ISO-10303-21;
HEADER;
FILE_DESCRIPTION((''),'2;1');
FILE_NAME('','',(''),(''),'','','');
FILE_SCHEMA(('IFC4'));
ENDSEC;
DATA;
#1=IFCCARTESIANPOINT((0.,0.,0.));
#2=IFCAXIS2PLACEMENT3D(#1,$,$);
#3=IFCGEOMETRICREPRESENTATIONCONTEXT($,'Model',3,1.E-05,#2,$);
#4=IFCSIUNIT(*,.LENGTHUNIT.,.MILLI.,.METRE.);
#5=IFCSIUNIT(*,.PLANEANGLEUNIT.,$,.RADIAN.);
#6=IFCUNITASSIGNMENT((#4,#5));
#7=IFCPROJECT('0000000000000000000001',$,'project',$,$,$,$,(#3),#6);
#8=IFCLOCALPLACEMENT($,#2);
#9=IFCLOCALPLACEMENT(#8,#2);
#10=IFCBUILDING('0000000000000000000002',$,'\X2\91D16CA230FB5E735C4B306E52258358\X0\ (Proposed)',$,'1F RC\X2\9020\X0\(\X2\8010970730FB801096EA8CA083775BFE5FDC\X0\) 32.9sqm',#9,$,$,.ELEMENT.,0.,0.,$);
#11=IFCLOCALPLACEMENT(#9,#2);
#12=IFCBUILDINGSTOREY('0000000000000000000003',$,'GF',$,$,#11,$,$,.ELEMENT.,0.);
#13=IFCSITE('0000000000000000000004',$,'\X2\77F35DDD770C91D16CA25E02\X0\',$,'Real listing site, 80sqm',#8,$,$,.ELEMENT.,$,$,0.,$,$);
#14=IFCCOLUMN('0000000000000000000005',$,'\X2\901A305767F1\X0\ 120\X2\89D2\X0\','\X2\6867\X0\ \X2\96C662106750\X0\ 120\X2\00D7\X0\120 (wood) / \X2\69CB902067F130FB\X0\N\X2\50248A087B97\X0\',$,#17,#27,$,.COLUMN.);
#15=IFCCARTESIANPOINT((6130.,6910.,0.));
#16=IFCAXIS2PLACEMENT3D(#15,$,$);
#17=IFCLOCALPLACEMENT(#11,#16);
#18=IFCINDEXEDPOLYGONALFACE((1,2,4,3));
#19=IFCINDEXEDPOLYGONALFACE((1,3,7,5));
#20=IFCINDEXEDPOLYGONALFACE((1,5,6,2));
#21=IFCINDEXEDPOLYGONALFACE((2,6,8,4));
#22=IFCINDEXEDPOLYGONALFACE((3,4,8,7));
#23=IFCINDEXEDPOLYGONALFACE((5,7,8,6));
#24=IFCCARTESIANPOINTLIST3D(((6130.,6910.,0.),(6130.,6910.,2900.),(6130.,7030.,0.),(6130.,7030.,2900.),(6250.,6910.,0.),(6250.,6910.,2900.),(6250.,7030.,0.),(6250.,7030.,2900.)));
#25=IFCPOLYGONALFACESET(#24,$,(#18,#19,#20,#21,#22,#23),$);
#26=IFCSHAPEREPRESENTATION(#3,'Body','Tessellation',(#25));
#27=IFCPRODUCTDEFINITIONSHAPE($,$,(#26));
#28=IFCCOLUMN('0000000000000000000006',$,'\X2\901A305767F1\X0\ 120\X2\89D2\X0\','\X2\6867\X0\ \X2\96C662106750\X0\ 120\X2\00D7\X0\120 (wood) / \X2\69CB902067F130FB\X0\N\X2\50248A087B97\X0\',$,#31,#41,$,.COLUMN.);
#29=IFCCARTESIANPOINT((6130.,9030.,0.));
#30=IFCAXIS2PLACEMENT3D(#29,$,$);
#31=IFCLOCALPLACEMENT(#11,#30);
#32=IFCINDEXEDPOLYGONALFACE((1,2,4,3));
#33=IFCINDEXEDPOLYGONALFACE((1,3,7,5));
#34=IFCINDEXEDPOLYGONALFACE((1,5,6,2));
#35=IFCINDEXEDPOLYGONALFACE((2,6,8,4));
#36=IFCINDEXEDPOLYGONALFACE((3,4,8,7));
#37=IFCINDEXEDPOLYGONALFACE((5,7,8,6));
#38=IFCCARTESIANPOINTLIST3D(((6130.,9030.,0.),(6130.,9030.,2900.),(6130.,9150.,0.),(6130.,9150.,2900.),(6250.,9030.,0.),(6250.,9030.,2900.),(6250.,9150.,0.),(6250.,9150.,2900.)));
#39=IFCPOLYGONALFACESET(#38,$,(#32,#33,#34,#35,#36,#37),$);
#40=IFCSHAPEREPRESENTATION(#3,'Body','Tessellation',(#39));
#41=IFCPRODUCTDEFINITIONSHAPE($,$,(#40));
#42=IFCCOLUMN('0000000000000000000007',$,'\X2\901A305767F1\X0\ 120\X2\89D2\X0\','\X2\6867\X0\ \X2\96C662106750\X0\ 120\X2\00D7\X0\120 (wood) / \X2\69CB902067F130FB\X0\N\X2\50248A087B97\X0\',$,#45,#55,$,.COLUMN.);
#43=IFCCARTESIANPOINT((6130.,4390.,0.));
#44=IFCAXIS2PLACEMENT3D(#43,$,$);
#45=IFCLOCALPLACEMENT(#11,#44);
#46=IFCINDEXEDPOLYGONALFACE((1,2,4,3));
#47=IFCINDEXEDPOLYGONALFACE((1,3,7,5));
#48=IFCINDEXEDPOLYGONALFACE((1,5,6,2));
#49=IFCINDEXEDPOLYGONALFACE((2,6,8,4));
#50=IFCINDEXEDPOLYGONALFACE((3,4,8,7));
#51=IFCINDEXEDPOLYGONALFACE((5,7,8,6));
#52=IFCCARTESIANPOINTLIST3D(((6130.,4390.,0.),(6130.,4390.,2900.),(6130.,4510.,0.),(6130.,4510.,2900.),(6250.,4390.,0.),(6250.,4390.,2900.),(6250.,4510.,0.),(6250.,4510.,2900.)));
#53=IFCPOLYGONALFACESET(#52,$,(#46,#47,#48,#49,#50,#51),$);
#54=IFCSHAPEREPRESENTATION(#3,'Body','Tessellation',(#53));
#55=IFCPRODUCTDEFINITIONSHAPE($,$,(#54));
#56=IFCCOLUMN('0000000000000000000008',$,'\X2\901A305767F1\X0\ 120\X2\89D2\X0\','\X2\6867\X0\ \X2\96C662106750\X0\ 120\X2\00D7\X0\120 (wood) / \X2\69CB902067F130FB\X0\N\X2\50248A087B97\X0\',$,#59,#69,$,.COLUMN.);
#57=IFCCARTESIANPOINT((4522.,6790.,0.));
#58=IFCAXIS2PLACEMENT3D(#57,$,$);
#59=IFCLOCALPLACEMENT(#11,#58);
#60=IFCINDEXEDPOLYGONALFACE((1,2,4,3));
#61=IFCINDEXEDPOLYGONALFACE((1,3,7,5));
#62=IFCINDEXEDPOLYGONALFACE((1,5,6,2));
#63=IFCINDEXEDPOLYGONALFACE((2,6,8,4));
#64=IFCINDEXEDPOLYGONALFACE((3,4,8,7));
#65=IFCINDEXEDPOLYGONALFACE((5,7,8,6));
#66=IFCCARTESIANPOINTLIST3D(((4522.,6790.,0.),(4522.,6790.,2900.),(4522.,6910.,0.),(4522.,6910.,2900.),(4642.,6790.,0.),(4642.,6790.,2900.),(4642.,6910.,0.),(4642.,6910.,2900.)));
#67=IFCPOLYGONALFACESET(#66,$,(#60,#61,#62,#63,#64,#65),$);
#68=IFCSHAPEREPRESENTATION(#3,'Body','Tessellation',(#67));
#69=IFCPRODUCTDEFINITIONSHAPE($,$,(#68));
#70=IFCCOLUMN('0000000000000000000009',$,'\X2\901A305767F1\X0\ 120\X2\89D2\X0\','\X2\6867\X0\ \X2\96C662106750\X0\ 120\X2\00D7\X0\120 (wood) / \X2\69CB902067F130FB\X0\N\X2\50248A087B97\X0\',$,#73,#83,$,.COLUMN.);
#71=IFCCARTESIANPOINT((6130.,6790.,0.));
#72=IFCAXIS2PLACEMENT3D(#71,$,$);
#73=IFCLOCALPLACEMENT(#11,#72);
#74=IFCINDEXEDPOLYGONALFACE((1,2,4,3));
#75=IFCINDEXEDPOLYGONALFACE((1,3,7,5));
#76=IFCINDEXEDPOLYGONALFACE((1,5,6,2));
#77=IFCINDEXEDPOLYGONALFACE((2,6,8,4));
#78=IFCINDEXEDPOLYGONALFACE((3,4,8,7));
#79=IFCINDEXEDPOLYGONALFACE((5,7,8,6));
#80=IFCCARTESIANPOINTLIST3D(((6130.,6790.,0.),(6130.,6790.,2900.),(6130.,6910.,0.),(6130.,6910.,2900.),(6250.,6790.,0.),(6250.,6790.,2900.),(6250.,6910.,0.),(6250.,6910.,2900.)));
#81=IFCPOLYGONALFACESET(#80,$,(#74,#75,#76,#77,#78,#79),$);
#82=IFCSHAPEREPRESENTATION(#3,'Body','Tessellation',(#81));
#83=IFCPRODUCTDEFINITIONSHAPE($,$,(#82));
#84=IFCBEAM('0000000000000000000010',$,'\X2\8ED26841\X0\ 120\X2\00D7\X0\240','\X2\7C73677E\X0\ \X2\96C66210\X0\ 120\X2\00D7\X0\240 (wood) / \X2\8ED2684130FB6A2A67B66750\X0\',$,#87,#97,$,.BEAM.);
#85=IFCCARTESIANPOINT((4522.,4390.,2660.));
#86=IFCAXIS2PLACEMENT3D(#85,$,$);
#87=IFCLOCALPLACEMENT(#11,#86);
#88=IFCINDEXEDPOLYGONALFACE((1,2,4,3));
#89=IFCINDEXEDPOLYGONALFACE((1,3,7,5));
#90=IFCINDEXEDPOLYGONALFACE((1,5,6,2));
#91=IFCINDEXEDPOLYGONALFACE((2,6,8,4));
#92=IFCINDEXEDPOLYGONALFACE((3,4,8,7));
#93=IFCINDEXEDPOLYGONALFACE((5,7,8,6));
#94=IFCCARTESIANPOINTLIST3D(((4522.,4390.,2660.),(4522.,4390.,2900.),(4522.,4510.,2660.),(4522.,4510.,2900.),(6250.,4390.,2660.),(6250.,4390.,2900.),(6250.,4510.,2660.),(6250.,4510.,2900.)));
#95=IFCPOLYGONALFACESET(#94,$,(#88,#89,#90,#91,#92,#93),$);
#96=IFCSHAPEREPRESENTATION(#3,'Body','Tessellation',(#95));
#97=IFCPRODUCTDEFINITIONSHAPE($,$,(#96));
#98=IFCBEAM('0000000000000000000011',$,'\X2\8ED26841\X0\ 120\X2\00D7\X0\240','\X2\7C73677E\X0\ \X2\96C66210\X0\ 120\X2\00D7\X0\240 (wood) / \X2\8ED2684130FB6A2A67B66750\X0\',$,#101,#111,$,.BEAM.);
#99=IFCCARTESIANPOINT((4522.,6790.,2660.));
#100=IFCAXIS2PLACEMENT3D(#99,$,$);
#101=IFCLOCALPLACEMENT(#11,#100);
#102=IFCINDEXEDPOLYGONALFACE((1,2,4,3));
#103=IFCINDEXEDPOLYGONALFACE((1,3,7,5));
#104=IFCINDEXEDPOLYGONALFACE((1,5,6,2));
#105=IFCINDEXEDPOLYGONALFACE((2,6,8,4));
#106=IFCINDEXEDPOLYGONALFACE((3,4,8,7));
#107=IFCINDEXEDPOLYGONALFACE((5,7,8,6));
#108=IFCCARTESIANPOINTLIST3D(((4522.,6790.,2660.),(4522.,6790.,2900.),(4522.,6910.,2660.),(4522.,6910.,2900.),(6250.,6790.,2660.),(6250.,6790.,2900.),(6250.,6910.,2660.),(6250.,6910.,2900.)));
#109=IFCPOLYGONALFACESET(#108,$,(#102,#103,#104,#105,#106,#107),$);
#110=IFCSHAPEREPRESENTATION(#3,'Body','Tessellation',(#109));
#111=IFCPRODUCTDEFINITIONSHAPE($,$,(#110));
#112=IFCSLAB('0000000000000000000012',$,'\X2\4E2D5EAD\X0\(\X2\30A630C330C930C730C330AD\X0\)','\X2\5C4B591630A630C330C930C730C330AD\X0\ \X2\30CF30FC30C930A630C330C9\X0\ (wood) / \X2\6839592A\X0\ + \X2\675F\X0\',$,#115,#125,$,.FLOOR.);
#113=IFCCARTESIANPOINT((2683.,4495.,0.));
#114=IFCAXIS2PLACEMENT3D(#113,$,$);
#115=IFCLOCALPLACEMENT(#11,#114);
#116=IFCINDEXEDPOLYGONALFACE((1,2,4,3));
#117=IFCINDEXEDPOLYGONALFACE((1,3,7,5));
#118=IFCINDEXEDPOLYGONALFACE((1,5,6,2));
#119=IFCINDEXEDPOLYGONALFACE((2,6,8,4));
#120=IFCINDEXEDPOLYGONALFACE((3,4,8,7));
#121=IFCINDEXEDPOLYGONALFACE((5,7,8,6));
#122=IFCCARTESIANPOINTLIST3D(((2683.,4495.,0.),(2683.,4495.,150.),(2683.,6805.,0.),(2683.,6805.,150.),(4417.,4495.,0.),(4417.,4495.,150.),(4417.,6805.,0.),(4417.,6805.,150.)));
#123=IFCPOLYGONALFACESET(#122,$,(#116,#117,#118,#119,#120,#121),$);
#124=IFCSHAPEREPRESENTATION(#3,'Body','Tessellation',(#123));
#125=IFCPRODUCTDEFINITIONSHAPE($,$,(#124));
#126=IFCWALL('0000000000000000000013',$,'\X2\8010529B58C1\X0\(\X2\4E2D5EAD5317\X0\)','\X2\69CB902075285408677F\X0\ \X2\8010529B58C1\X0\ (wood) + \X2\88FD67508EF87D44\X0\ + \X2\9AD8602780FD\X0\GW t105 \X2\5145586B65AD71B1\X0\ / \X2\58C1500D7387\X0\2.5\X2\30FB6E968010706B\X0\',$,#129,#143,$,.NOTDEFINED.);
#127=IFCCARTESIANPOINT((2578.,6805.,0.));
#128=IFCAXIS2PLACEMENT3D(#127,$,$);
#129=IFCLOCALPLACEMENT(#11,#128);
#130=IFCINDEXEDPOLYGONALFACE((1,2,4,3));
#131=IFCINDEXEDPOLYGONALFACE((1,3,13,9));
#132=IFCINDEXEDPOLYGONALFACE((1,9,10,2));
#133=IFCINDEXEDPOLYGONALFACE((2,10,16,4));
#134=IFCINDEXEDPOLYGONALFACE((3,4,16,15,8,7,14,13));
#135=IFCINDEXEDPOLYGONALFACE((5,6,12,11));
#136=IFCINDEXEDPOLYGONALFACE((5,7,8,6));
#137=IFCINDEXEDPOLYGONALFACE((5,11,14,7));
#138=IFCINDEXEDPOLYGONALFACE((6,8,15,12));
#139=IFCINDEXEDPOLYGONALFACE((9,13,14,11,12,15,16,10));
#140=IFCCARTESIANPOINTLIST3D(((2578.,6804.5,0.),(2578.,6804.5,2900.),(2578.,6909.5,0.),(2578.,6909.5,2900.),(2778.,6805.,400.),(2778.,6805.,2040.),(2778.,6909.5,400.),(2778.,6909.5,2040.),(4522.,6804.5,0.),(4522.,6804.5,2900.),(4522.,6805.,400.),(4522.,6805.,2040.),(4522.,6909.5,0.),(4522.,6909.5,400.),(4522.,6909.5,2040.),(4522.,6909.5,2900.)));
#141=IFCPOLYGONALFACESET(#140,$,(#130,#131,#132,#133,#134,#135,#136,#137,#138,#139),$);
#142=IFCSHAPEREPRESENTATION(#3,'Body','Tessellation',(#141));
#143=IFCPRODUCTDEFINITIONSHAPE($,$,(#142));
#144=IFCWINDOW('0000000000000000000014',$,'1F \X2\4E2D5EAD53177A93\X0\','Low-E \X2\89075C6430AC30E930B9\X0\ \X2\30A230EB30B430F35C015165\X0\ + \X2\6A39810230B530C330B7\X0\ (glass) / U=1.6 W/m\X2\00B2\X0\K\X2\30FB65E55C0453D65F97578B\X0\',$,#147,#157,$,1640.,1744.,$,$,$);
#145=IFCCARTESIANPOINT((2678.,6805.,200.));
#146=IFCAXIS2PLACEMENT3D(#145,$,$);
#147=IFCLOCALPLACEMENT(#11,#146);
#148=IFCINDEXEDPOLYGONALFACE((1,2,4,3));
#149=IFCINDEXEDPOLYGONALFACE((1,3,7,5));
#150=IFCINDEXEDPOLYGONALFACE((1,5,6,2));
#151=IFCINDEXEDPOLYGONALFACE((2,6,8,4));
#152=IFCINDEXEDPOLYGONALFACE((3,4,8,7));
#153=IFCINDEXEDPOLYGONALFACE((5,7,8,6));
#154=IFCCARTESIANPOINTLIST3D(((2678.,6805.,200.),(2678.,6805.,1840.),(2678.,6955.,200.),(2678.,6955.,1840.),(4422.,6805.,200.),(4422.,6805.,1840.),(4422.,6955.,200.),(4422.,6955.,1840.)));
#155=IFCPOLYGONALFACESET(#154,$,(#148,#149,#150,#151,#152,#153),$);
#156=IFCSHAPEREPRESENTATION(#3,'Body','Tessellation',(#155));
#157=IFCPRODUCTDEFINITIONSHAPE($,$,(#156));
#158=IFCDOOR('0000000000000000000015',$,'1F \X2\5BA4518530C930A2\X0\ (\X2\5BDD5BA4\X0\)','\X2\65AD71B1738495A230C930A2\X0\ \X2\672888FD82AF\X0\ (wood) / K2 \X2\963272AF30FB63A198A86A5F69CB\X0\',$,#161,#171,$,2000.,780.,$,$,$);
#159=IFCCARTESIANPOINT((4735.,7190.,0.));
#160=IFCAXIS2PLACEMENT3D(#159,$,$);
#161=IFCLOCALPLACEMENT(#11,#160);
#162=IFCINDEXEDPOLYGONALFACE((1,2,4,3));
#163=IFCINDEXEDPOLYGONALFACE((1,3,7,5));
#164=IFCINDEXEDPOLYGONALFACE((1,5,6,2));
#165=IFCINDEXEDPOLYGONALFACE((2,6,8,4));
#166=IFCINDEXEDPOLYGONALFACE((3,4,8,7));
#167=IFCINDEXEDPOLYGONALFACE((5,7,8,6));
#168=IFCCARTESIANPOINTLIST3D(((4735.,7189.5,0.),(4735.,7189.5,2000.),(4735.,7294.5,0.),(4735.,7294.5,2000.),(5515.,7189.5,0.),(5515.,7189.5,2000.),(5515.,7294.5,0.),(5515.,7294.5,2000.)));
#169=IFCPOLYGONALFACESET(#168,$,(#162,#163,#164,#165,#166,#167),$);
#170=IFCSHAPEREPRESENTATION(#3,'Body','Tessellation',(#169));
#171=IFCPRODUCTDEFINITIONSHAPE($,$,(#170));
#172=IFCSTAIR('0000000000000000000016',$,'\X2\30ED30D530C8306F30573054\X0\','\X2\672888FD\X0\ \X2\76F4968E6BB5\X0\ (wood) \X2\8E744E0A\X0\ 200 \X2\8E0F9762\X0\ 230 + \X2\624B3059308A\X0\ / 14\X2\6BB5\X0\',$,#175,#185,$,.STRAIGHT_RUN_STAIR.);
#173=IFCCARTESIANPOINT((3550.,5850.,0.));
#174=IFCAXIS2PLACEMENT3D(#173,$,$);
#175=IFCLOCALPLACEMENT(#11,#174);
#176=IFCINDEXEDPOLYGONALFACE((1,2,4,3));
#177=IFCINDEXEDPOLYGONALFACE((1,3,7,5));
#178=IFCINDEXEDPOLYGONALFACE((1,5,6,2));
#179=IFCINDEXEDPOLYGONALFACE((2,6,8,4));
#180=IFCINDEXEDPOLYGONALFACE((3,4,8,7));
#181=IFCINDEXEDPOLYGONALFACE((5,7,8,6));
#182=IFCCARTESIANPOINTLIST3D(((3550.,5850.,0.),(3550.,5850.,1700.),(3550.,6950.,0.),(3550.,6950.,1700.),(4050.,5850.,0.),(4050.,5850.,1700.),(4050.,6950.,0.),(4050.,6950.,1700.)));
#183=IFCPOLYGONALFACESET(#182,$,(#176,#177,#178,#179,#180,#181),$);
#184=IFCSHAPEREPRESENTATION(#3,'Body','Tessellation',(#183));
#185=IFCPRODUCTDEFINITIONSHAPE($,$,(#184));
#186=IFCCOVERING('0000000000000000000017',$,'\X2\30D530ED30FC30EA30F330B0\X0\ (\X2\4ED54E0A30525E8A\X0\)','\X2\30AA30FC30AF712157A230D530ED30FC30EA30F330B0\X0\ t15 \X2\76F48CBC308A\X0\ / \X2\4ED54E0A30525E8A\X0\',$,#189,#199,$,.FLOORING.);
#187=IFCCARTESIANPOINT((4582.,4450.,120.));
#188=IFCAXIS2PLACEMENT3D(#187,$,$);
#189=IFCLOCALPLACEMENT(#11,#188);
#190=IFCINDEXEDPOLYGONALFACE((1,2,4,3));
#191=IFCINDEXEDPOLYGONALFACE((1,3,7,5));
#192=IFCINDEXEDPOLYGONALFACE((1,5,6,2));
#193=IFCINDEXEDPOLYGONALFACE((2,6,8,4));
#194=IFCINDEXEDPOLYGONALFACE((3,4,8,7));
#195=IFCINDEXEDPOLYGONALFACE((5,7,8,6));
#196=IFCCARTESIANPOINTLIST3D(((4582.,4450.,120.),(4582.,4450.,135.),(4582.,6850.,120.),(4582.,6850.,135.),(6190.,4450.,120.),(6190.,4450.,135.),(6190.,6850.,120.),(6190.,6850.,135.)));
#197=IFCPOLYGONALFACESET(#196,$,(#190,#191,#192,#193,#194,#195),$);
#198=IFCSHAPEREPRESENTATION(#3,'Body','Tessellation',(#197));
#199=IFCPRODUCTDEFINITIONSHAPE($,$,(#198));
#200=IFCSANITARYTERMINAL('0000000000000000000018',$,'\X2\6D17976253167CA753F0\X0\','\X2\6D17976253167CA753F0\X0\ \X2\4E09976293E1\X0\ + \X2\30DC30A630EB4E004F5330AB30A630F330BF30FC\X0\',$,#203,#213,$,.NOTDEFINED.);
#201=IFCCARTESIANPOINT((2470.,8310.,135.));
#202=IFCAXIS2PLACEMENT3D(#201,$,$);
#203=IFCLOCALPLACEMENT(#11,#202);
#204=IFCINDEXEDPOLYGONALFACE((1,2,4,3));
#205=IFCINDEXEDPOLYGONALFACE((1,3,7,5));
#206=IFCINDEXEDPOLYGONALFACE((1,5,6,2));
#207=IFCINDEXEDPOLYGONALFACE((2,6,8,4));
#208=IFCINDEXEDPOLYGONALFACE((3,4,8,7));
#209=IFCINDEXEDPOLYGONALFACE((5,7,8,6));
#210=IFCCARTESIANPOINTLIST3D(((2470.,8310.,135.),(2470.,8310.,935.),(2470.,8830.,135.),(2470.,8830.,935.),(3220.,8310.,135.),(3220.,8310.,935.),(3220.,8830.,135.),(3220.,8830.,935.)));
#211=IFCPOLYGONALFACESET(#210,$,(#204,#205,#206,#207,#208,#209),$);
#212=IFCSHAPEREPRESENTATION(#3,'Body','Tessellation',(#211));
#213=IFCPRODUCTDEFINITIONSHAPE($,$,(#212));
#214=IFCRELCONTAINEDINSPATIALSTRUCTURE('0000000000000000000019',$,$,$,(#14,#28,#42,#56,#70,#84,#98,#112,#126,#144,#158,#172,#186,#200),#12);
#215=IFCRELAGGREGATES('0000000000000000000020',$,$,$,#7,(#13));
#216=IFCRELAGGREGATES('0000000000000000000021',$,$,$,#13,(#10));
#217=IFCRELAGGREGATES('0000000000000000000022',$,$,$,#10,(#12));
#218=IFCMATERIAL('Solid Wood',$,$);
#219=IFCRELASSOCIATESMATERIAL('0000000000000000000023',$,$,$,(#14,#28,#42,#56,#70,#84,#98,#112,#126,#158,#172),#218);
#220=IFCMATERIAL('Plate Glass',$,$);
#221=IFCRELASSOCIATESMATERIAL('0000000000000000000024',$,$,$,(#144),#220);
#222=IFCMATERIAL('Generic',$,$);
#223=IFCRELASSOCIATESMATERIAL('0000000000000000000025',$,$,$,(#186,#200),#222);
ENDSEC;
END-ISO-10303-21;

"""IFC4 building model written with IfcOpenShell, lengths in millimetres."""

from ifc_helpers import new_model, si_unit, frame, frame_2d, origin, place, context, project, spatial, rectangle, extrude, material, element, fill, save


model = new_model("IFC4")

# Units and contexts
model_context = context("Model", 3, precision=1e-05, world=origin())
ifc_project = project(units=[si_unit("LENGTHUNIT", "METRE", prefix="MILLI"), si_unit("PLANEANGLEUNIT", "RADIAN")], contexts=[model_context])

# Site, building, storey
site_placement = place(None, origin())
site = spatial("IfcSite", under=ifc_project, at=site_placement, Name="石川県金沢市", ObjectType="Real listing site, 80sqm", CompositionType="ELEMENT", RefElevation=0.0)
building_placement = place(site_placement, origin())
building = spatial("IfcBuilding", under=site, at=building_placement, Name="金沢・平屋の別荘 (Proposed)", ObjectType="1F RC造(耐震・耐雪負荷対応) 32.9sqm", CompositionType="ELEMENT", ElevationOfRefHeight=0.0, ElevationOfTerrain=0.0)
storey_placement = place(building_placement, origin())
storey = spatial("IfcBuildingStorey", under=building, at=storey_placement, Name="GF", CompositionType="ELEMENT", Elevation=0.0)

# Columns
ifc_material_1 = material(Name="Solid Wood")
column_1_placement = place(storey_placement, frame((6130.0, 6910.0, 0.0)))
element("IfcColumn", 1, at=column_1_placement, inside=storey, material=ifc_material_1, Name="通し柱 120角", Description="桧 集成材 120×120 (wood) / 構造柱・N値計算", PredefinedType="COLUMN", context=model_context, shape_type="SweptSolid", body=[
    extrude(rectangle(XDim=120.0, YDim=120.0, at=frame_2d((60.0, 60.0))), frame((6130.0, 6910.0, 0.0)), (0.0, 0.0, 1.0), 2900.0),
])
column_2_placement = place(storey_placement, frame((6130.0, 9030.0, 0.0)))
element("IfcColumn", 2, at=column_2_placement, inside=storey, material=ifc_material_1, Name="通し柱 120角", Description="桧 集成材 120×120 (wood) / 構造柱・N値計算", PredefinedType="COLUMN", context=model_context, shape_type="SweptSolid", body=[
    extrude(rectangle(XDim=120.0, YDim=120.0, at=frame_2d((60.0, 60.0))), frame((6130.0, 9030.0, 0.0)), (0.0, 0.0, 1.0), 2900.0),
])
column_3_placement = place(storey_placement, frame((6130.0, 4390.0, 0.0)))
element("IfcColumn", 3, at=column_3_placement, inside=storey, material=ifc_material_1, Name="通し柱 120角", Description="桧 集成材 120×120 (wood) / 構造柱・N値計算", PredefinedType="COLUMN", context=model_context, shape_type="SweptSolid", body=[
    extrude(rectangle(XDim=120.0, YDim=120.0, at=frame_2d((60.0, 60.0))), frame((6130.0, 4390.0, 0.0)), (0.0, 0.0, 1.0), 2900.0),
])
column_4_placement = place(storey_placement, frame((4522.0, 6790.0, 0.0)))
element("IfcColumn", 4, at=column_4_placement, inside=storey, material=ifc_material_1, Name="通し柱 120角", Description="桧 集成材 120×120 (wood) / 構造柱・N値計算", PredefinedType="COLUMN", context=model_context, shape_type="SweptSolid", body=[
    extrude(rectangle(XDim=120.0, YDim=120.0, at=frame_2d((60.0, 60.0))), frame((4522.0, 6790.0, 0.0)), (0.0, 0.0, 1.0), 2900.0),
])
column_5_placement = place(storey_placement, frame((6130.0, 6790.0, 0.0)))
element("IfcColumn", 5, at=column_5_placement, inside=storey, material=ifc_material_1, Name="通し柱 120角", Description="桧 集成材 120×120 (wood) / 構造柱・N値計算", PredefinedType="COLUMN", context=model_context, shape_type="SweptSolid", body=[
    extrude(rectangle(XDim=120.0, YDim=120.0, at=frame_2d((60.0, 60.0))), frame((6130.0, 6790.0, 0.0)), (0.0, 0.0, 1.0), 2900.0),
])

# Beams
beam_1_placement = place(storey_placement, frame((4522.0, 4390.0, 2660.0)))
element("IfcBeam", 6, at=beam_1_placement, inside=storey, material=ifc_material_1, Name="軒桁 120×240", Description="米松 集成 120×240 (wood) / 軒桁・横架材", PredefinedType="BEAM", context=model_context, shape_type="SweptSolid", body=[
    extrude(rectangle(XDim=1728.0, YDim=120.0, at=frame_2d((864.0, 60.0))), frame((4522.0, 4390.0, 2660.0)), (0.0, 0.0, 1.0), 240.0),
])
beam_2_placement = place(storey_placement, frame((4522.0, 6790.0, 2660.0)))
element("IfcBeam", 7, at=beam_2_placement, inside=storey, material=ifc_material_1, Name="軒桁 120×240", Description="米松 集成 120×240 (wood) / 軒桁・横架材", PredefinedType="BEAM", context=model_context, shape_type="SweptSolid", body=[
    extrude(rectangle(XDim=1728.0, YDim=120.0, at=frame_2d((864.0, 60.0))), frame((4522.0, 6790.0, 2660.0)), (0.0, 0.0, 1.0), 240.0),
])

# Slab
slab_placement = place(storey_placement, frame((2683.0, 4495.0, 0.0)))
element("IfcSlab", 8, at=slab_placement, inside=storey, material=ifc_material_1, Name="中庭(ウッドデッキ)", Description="屋外ウッドデッキ ハードウッド (wood) / 根太 + 束", PredefinedType="FLOOR", context=model_context, shape_type="SweptSolid", body=[
    extrude(rectangle(XDim=1734.0, YDim=2310.0, at=frame_2d((867.0, 1155.0))), frame((2683.0, 4495.0, 0.0)), (0.0, 0.0, 1.0), 150.0),
])

# Wall, opening, window
wall_1_placement = place(storey_placement, frame((2578.0, 6805.0, 0.0)))
wall_1 = element("IfcWall", 9, at=wall_1_placement, inside=storey, material=ifc_material_1, Name="耐力壁(中庭北)", Description="構造用合板 耐力壁 (wood) + 製材軸組 + 高性能GW t105 充填断熱 / 壁倍率2.5・準耐火", PredefinedType="NOTDEFINED", context=model_context, shape_type="SweptSolid", body=[
    extrude(rectangle(XDim=1944.0, YDim=105.0, at=frame_2d((972.0, 52.0))), frame((2578.0, 6805.0, 0.0)), (0.0, 0.0, 1.0), 2900.0),
])
opening_placement = place(storey_placement, frame((2678.0, 6805.0, 200.0)))
opening = element("IfcOpeningElement", 10, at=opening_placement, cuts=wall_1, PredefinedType="NOTDEFINED", context=model_context, shape_type="SweptSolid", body=[
    extrude(rectangle(XDim=1744.0, YDim=150.0, at=frame_2d((872.0, 75.0))), frame((2678.0, 6805.0, 200.0)), (0.0, 0.0, 1.0), 1640.0),
])
ifc_material_2 = material(Name="Plate Glass")
window_placement = place(storey_placement, frame((2678.0, 6805.0, 200.0)))
window = element("IfcWindow", 11, at=window_placement, inside=storey, material=ifc_material_2, Name="1F 中庭北窓", Description="Low-E 複層ガラス アルゴン封入 + 樹脂サッシ (glass) / U=1.6 W/m²K・日射取得型", OverallHeight=1640.0, OverallWidth=1744.0, context=model_context, shape_type="SweptSolid", body=[
    extrude(rectangle(XDim=1744.0, YDim=150.0, at=frame_2d((872.0, 75.0))), frame((2678.0, 6805.0, 200.0)), (0.0, 0.0, 1.0), 1640.0),
])
fill(opening, window)

# Door
door_placement = place(storey_placement, frame((4735.0, 7190.0, 0.0)))
element("IfcDoor", 12, at=door_placement, inside=storey, material=ifc_material_1, Name="1F 室内ドア (寝室)", Description="断熱玄関ドア 木製芯 (wood) / K2 防犯・採風機構", OverallHeight=2000.0, OverallWidth=780.0, context=model_context, shape_type="SweptSolid", body=[
    extrude(rectangle(XDim=780.0, YDim=105.0, at=frame_2d((390.0, 52.0))), frame((4735.0, 7190.0, 0.0)), (0.0, 0.0, 1.0), 2000.0),
])

# Stair
stair_placement = place(storey_placement, frame((3550.0, 5850.0, 0.0)))
element("IfcStair", 13, at=stair_placement, inside=storey, material=ifc_material_1, Name="ロフトはしご", Description="木製 直階段 (wood) 蹴上 200 踏面 230 + 手すり / 14段", PredefinedType="STRAIGHT_RUN_STAIR", context=model_context, shape_type="SweptSolid", body=[
    extrude(rectangle(XDim=500.0, YDim=1100.0, at=frame_2d((250.0, 550.0))), frame((3550.0, 5850.0, 0.0)), (0.0, 0.0, 1.0), 1700.0),
])

# Covering
ifc_material_3 = material(Name="Generic")
covering_placement = place(storey_placement, frame((4582.0, 4450.0, 120.0)))
element("IfcCovering", 14, at=covering_placement, inside=storey, material=ifc_material_3, Name="フローリング (仕上げ床)", Description="オーク無垢フローリング t15 直貼り / 仕上げ床", PredefinedType="FLOORING", context=model_context, shape_type="SweptSolid", body=[
    extrude(rectangle(XDim=1608.0, YDim=2400.0, at=frame_2d((804.0, 1200.0))), frame((4582.0, 4450.0, 120.0)), (0.0, 0.0, 1.0), 15.0),
])

# Sanitary terminal
sanitary_terminal_1_placement = place(storey_placement, frame((2470.0, 8310.0, 135.0)))
element("IfcSanitaryTerminal", 15, at=sanitary_terminal_1_placement, inside=storey, material=ifc_material_3, Name="洗面化粧台", Description="洗面化粧台 三面鏡 + ボウル一体カウンター", PredefinedType="NOTDEFINED", context=model_context, shape_type="SweptSolid", body=[
    extrude(rectangle(XDim=750.0, YDim=520.0, at=frame_2d((375.0, 260.0))), frame((2470.0, 8310.0, 135.0)), (0.0, 0.0, 1.0), 800.0),
])

save(model, "model.ifc")
